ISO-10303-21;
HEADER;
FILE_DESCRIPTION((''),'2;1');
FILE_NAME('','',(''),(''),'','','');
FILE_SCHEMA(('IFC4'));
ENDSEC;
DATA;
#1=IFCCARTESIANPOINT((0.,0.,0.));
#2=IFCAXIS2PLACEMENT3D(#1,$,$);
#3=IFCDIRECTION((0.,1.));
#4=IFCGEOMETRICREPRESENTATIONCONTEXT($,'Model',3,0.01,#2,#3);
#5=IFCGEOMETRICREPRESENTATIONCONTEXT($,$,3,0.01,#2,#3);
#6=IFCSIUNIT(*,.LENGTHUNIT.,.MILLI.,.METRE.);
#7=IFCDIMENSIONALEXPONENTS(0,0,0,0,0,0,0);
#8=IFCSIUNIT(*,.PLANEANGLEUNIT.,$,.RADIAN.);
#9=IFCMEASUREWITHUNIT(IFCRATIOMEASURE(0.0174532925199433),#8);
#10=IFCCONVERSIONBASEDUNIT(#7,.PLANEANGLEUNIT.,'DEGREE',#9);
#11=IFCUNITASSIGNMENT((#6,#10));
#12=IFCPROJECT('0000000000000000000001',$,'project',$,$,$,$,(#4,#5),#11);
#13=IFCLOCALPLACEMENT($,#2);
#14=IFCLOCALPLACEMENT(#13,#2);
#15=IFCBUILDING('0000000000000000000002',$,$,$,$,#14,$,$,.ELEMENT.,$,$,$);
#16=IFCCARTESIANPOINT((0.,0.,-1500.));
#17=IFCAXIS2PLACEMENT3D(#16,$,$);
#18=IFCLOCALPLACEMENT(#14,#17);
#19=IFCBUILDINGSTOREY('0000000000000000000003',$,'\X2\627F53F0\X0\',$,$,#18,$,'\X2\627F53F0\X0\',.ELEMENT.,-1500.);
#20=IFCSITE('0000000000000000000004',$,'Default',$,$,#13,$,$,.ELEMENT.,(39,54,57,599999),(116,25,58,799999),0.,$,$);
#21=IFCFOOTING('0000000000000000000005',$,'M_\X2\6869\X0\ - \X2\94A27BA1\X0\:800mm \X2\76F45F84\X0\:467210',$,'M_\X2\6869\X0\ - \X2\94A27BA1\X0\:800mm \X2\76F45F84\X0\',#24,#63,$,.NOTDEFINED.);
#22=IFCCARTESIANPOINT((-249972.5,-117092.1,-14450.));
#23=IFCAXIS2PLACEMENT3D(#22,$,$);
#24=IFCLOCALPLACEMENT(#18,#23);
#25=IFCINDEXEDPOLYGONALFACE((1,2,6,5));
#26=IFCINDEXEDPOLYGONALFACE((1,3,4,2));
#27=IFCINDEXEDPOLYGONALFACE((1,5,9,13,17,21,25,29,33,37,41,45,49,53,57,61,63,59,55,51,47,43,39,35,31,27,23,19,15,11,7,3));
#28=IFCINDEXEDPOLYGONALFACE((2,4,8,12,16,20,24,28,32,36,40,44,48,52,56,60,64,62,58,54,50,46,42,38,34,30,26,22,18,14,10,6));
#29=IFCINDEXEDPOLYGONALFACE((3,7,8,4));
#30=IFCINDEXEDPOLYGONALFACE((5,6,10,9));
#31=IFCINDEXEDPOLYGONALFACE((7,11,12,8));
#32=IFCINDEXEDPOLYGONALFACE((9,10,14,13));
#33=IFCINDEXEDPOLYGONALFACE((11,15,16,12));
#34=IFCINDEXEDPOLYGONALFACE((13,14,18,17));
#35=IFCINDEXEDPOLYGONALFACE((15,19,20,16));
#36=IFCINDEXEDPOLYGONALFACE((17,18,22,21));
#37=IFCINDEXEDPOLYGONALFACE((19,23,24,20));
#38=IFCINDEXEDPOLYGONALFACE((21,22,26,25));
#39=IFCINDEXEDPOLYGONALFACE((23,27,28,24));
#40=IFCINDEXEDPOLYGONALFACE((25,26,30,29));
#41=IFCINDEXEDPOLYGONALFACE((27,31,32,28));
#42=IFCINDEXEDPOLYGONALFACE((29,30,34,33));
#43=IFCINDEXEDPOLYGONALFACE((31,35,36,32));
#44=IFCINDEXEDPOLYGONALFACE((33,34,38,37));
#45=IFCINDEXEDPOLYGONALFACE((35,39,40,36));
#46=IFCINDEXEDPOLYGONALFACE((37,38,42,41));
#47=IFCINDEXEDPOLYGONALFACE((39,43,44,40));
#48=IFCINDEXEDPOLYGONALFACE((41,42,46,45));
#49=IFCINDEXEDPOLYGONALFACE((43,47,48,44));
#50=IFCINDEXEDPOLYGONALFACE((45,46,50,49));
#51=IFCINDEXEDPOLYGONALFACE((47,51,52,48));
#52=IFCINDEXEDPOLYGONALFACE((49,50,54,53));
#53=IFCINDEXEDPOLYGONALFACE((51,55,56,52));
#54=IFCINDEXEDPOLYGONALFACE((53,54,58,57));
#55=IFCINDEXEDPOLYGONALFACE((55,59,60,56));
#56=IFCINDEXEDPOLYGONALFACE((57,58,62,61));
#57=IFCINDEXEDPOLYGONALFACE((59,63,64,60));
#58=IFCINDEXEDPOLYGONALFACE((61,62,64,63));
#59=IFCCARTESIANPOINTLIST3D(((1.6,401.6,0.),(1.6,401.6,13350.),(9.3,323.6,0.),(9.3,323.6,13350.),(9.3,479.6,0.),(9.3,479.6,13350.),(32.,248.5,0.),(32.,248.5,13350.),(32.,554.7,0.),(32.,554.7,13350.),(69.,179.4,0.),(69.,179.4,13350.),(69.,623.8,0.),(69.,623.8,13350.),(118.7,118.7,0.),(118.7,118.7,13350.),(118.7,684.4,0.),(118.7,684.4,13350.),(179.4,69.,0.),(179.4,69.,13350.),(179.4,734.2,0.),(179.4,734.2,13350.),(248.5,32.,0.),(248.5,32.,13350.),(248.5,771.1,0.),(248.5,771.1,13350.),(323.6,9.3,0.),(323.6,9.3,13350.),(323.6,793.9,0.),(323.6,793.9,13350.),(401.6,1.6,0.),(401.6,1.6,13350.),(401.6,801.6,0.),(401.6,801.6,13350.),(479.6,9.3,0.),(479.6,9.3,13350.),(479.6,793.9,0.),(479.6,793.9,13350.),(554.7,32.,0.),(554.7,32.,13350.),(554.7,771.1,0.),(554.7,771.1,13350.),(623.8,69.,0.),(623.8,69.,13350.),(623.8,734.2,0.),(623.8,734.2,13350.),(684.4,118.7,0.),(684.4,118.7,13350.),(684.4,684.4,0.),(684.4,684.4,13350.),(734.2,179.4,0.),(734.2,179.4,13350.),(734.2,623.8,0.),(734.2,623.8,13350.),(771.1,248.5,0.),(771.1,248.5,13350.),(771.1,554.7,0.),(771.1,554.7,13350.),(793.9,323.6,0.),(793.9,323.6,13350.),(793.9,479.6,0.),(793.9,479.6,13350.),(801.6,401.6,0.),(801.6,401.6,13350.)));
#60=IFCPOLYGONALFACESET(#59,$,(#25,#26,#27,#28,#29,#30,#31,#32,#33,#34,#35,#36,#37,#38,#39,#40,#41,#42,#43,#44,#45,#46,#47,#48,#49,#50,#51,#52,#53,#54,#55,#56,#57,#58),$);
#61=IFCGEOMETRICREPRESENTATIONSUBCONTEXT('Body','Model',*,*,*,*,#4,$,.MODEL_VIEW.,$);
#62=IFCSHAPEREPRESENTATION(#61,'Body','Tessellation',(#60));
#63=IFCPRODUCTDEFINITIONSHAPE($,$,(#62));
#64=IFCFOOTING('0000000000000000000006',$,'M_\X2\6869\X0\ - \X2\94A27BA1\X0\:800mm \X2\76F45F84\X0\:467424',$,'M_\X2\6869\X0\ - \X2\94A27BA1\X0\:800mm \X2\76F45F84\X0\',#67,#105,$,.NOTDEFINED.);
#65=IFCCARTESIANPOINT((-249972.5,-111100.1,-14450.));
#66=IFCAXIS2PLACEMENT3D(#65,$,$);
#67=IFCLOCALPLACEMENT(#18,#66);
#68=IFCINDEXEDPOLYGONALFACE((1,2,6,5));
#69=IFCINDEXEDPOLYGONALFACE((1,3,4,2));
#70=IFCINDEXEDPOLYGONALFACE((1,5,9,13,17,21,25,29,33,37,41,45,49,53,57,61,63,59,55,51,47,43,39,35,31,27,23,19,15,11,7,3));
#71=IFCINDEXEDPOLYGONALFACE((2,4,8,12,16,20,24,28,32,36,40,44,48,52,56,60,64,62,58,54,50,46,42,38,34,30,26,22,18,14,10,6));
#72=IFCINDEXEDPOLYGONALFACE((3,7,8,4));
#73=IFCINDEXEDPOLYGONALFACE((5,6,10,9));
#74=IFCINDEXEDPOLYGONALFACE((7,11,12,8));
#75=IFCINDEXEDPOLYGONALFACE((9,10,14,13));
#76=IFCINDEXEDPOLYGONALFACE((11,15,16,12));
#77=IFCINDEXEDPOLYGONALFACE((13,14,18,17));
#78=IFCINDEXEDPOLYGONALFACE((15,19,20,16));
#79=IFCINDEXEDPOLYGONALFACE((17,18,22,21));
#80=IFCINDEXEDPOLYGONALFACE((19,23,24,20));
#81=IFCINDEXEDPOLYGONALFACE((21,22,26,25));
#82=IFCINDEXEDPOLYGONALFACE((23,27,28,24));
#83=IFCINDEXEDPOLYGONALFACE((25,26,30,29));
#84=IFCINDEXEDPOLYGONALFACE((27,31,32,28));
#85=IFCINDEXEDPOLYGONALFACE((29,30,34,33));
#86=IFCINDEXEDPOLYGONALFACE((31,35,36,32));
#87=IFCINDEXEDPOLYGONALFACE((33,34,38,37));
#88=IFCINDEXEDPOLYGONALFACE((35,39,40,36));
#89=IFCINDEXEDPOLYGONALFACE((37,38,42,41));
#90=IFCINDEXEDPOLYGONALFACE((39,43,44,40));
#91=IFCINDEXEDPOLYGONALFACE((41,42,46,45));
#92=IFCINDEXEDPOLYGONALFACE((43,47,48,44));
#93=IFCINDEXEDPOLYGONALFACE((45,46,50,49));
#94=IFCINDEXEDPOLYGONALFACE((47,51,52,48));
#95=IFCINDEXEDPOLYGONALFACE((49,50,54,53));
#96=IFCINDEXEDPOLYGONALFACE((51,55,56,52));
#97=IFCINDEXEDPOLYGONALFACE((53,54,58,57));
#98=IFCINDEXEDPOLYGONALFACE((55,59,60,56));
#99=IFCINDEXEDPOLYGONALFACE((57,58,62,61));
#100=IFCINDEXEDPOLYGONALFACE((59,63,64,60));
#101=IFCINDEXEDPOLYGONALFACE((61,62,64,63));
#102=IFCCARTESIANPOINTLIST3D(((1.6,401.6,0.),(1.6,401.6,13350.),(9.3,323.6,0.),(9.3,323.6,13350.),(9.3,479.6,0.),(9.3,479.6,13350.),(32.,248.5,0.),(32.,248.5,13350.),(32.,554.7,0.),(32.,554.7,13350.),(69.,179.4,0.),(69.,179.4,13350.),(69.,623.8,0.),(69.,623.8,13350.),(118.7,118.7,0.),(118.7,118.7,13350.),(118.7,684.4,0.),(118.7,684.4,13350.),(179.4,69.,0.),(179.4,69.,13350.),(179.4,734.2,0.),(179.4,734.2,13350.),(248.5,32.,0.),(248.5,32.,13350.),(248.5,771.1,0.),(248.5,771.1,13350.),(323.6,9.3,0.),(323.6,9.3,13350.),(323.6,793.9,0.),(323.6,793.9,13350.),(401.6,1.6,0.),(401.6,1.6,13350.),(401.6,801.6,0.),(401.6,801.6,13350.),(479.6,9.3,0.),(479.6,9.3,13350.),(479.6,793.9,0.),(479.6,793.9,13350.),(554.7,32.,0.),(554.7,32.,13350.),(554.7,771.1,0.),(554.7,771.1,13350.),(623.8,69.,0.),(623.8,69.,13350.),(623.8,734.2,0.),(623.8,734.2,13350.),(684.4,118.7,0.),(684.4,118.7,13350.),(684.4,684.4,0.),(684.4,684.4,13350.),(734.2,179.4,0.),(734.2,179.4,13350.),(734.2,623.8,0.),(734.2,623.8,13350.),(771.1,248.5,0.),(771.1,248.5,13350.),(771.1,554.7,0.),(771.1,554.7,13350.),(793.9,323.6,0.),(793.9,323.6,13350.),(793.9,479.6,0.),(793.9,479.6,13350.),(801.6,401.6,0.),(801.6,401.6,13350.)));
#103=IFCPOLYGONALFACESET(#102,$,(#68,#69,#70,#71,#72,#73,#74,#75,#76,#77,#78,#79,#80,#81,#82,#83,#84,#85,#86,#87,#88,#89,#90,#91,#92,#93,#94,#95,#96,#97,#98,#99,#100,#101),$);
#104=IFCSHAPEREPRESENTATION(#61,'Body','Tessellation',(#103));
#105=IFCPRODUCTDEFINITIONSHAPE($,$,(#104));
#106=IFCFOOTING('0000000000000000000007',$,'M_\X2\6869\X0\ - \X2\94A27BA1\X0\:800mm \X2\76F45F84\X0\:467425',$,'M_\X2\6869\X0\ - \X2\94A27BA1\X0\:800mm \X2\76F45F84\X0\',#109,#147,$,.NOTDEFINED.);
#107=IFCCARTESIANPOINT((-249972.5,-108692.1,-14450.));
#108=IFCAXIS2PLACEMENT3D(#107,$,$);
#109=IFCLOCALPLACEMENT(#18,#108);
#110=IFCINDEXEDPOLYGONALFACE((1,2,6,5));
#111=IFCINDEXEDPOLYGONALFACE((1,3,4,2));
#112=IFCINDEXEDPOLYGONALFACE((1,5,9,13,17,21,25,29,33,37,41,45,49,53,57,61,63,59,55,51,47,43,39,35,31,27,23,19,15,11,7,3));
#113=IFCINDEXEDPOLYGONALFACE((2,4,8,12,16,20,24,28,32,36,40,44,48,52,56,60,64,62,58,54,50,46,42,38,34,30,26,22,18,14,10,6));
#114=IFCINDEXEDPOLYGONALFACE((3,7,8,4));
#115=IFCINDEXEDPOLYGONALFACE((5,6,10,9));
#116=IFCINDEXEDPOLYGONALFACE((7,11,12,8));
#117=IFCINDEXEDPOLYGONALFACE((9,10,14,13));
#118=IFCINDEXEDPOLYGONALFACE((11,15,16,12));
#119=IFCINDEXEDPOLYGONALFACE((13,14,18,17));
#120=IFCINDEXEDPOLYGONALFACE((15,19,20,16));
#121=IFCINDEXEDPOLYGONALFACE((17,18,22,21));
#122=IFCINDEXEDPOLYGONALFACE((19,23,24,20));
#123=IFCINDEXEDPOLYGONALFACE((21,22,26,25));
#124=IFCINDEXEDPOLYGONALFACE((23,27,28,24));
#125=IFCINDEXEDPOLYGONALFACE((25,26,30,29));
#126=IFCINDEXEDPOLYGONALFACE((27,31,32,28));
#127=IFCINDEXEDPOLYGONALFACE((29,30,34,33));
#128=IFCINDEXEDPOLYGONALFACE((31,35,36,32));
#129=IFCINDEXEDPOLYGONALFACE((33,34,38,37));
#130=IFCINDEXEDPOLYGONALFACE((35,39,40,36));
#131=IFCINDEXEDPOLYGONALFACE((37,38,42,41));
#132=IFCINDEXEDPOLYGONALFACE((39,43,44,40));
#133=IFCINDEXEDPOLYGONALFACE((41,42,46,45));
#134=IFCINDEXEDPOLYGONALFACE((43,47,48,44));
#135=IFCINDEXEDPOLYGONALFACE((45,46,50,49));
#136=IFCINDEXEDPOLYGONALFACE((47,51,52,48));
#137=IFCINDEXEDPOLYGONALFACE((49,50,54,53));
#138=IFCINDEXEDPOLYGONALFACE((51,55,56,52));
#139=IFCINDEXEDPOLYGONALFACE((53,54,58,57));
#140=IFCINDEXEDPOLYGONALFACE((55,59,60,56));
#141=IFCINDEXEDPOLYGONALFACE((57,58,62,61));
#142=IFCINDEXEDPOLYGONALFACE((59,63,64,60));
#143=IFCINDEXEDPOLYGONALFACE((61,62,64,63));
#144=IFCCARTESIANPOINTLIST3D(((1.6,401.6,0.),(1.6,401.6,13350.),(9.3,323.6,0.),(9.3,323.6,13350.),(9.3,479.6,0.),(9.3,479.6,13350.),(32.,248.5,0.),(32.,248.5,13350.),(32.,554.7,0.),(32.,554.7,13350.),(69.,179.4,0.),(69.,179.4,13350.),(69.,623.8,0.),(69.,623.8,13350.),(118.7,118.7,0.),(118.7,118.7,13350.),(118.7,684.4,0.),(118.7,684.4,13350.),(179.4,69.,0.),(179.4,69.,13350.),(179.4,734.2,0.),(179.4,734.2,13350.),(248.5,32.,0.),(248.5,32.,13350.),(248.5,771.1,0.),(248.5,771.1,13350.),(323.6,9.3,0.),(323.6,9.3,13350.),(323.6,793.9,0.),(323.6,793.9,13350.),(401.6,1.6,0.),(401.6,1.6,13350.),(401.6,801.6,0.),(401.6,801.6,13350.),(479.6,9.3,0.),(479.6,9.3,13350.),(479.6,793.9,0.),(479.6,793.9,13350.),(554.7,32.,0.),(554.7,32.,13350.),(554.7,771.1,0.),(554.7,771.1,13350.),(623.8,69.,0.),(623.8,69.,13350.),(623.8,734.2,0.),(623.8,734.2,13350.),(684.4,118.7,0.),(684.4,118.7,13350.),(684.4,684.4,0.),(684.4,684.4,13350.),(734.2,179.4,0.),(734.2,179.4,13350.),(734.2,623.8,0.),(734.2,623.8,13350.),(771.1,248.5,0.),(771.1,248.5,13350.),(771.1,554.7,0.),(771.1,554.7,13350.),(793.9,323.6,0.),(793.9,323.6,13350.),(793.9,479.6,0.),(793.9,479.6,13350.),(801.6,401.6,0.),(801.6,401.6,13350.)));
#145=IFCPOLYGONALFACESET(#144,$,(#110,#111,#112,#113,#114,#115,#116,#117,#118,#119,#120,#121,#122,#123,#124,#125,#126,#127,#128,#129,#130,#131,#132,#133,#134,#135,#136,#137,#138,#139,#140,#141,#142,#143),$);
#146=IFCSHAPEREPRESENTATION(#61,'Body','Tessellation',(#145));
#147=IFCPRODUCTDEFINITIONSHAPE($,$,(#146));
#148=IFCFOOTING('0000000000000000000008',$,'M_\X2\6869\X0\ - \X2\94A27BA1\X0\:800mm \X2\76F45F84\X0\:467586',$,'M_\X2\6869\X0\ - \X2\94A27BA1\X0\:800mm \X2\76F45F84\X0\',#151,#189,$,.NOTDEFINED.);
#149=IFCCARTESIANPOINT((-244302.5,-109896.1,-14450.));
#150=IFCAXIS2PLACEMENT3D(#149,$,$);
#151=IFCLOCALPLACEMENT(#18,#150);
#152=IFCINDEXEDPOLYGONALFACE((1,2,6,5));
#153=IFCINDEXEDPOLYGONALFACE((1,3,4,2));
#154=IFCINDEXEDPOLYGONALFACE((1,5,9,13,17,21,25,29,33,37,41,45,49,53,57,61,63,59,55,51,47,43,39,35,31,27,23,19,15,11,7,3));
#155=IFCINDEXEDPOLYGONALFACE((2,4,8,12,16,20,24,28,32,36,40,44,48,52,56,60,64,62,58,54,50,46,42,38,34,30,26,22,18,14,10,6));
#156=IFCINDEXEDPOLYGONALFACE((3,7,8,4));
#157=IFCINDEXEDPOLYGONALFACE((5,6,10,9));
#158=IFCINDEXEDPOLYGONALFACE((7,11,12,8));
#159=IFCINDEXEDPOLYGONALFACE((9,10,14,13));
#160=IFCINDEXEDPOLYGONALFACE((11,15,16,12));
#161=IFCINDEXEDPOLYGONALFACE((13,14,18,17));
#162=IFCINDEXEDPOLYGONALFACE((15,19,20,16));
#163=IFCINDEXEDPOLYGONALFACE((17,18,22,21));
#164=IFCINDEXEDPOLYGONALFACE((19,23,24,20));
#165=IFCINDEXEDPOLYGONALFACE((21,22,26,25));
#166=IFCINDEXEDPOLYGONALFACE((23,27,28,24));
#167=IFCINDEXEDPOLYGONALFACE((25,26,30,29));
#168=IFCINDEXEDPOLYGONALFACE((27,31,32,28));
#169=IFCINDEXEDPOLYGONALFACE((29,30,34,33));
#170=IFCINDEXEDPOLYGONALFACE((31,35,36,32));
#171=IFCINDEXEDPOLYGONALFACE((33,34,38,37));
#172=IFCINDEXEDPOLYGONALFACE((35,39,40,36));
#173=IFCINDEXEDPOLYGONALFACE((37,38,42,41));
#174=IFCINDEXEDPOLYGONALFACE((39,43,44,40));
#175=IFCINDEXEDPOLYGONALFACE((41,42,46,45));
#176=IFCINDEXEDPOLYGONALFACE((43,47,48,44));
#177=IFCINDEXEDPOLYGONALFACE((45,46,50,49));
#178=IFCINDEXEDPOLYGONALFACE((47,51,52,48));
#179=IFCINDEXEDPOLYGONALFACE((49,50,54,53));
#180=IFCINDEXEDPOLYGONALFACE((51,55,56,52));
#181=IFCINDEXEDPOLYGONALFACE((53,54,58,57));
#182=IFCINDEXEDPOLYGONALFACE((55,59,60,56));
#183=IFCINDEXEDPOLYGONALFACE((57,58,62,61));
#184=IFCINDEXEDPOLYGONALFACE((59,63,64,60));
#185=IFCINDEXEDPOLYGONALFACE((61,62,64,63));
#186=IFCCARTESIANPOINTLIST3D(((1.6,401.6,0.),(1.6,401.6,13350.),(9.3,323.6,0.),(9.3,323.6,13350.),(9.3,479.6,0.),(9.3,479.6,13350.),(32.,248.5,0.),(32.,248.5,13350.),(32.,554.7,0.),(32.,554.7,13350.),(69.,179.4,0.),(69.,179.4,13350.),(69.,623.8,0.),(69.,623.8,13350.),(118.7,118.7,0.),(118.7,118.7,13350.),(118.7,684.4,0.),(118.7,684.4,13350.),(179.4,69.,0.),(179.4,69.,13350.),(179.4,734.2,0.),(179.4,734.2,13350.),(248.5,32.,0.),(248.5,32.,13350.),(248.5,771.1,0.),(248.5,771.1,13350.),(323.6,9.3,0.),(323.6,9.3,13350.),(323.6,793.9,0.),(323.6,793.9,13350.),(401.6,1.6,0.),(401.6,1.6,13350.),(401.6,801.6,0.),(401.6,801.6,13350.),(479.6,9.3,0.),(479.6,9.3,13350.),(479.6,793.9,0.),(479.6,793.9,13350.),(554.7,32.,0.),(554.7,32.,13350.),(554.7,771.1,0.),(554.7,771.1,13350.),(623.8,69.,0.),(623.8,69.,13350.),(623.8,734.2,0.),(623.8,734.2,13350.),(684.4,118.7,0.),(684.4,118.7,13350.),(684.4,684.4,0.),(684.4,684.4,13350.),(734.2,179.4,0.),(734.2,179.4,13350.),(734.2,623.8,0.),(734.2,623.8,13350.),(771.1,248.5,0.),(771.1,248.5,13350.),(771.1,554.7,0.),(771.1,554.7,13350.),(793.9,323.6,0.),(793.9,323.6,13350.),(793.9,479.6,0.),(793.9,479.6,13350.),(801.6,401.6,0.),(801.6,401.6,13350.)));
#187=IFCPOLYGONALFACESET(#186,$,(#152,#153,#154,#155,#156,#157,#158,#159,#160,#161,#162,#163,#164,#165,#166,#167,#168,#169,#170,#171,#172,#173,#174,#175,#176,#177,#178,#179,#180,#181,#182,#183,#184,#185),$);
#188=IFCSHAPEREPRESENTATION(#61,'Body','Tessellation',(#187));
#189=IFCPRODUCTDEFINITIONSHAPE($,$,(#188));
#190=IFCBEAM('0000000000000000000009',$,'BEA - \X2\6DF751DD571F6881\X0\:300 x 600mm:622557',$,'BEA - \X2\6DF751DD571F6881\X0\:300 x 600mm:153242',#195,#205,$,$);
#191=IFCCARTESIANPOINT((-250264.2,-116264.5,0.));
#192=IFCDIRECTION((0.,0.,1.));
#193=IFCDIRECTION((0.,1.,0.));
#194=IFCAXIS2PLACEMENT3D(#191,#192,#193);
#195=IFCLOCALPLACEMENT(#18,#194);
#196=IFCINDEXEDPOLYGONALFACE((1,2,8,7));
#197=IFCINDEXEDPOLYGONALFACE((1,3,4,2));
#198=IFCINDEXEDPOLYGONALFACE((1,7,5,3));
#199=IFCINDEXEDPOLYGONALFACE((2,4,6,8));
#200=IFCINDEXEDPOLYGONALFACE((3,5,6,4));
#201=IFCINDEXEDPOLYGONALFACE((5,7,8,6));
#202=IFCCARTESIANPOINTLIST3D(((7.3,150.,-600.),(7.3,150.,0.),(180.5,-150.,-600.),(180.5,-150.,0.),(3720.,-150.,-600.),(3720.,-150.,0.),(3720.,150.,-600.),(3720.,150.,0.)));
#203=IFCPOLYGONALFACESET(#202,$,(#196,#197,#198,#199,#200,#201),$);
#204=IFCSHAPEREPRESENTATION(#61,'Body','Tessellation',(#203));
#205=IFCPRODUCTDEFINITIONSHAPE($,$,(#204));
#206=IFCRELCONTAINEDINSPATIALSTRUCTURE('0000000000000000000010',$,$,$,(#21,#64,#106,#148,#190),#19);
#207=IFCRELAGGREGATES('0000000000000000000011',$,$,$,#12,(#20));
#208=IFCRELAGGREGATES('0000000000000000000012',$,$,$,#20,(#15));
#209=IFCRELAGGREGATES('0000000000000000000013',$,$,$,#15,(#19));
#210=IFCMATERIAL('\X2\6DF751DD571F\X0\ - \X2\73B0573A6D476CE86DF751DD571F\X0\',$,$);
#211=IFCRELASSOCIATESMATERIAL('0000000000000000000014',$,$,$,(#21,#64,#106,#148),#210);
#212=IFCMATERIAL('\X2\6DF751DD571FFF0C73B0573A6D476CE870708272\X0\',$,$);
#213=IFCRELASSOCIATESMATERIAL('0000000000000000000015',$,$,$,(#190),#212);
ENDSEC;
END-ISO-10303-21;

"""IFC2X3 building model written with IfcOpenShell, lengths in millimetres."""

from ifc_helpers import new_model, entity, si_unit, converted_unit, direction, frame, origin, origin_2d_with_axis, place, context, subcontext, project, spatial, rectangle, circle, extrude, clip, halfspace, material, element, save


model = new_model("IFC2X3")

# Units and contexts
model_context = context("Model", 3, precision=0.01, world=origin(), true_north=direction((0.0, 1.0)))
context_of_model = context(None, 3, precision=0.01, world=origin(), true_north=direction((0.0, 1.0)))
body_context = subcontext(model_context, "Body", "Model", "MODEL_VIEW")
ifc_project = project(units=[si_unit("LENGTHUNIT", "METRE", prefix="MILLI"), converted_unit("PLANEANGLEUNIT", "DEGREE", entity("IfcRatioMeasure", 0.0174532925199433), si_unit("PLANEANGLEUNIT", "RADIAN"), dimensions=[0, 0, 0, 0, 0, 0, 0])], contexts=[model_context, context_of_model])

# Site, building, storey
site_placement = place(None, origin())
site = spatial("IfcSite", under=ifc_project, at=site_placement, Name="Default", CompositionType="ELEMENT", RefLatitude=(39, 54, 57, 599999), RefLongitude=(116, 25, 58, 799999), RefElevation=0.0)
building_placement = place(site_placement, origin())
building = spatial("IfcBuilding", under=site, at=building_placement, CompositionType="ELEMENT")
storey_placement = place(building_placement, frame((0.0, 0.0, -1500.0)))
storey = spatial("IfcBuildingStorey", under=building, at=storey_placement, Name="承台", LongName="承台", CompositionType="ELEMENT", Elevation=-1500.0)

# Footings
ifc_material_1 = material(Name="混凝土 - 现场浇注混凝土")
for number, where, name in (
    (1, (-249972.5, -117092.1, -14450.0), "M_桩 - 钢管:800mm 直径:467210"),
    (2, (-249972.5, -111100.1, -14450.0), "M_桩 - 钢管:800mm 直径:467424"),
    (3, (-249972.5, -108692.1, -14450.0), "M_桩 - 钢管:800mm 直径:467425"),
):
    element("IfcFooting", number, at=place(storey_placement, frame(where)), inside=storey, material=ifc_material_1, Name=name, ObjectType="M_桩 - 钢管:800mm 直径", PredefinedType="NOTDEFINED", context=body_context, shape_type="SweptSolid", body=[
        extrude(circle(Radius=400.0, at=origin_2d_with_axis()), frame((401.6, 401.6, 0.0), z_axis=(0.0, 0.0, 1.0), x_axis=(0.0, 1.0, 0.0)), (0.0, 0.0, 1.0), 13350.0),
    ])
footing_1_placement = place(storey_placement, frame((-244302.5, -109896.1, -14450.0)))
element("IfcFooting", 4, at=footing_1_placement, inside=storey, material=ifc_material_1, Name="M_桩 - 钢管:800mm 直径:467586", ObjectType="M_桩 - 钢管:800mm 直径", PredefinedType="NOTDEFINED", context=body_context, shape_type="SweptSolid", body=[
    extrude(circle(Radius=400.0, at=origin_2d_with_axis()), frame((401.6, 401.6, 0.0), z_axis=(0.0, 0.0, 1.0), x_axis=(0.0, 1.0, 0.0)), (0.0, 0.0, 1.0), 13350.0),
])

# Shared definitions
ifc_material_2 = material(Name="混凝土，现场浇注灰色")

# Beam
beam_1_placement = place(storey_placement, frame((-250264.2, -116264.5, 0.0), z_axis=(0.0, 0.0, 1.0), x_axis=(0.0, 1.0, 0.0)))
element("IfcBeam", 5, at=beam_1_placement, inside=storey, material=ifc_material_2, Name="BEA - 混凝土梁:300 x 600mm:622557", ObjectType="BEA - 混凝土梁:300 x 600mm:153242", context=body_context, shape_type="Clipping", body=[
    clip(extrude(rectangle(XDim=600.0, YDim=300.0, at=origin_2d_with_axis()), frame((7.3, 0.0, -300.0), z_axis=(1.0, 0.0, 0.0), x_axis=(0.0, 0.0, -1.0)), (0.0, 0.0, 1.0), 3712.7), halfspace(frame((494.0, -693.3, 0.0), z_axis=(-0.866125, -0.499827, 0.0), x_axis=(0.499827, -0.866125, 0.0)), False)),
])

save(model, "model.ifc")
